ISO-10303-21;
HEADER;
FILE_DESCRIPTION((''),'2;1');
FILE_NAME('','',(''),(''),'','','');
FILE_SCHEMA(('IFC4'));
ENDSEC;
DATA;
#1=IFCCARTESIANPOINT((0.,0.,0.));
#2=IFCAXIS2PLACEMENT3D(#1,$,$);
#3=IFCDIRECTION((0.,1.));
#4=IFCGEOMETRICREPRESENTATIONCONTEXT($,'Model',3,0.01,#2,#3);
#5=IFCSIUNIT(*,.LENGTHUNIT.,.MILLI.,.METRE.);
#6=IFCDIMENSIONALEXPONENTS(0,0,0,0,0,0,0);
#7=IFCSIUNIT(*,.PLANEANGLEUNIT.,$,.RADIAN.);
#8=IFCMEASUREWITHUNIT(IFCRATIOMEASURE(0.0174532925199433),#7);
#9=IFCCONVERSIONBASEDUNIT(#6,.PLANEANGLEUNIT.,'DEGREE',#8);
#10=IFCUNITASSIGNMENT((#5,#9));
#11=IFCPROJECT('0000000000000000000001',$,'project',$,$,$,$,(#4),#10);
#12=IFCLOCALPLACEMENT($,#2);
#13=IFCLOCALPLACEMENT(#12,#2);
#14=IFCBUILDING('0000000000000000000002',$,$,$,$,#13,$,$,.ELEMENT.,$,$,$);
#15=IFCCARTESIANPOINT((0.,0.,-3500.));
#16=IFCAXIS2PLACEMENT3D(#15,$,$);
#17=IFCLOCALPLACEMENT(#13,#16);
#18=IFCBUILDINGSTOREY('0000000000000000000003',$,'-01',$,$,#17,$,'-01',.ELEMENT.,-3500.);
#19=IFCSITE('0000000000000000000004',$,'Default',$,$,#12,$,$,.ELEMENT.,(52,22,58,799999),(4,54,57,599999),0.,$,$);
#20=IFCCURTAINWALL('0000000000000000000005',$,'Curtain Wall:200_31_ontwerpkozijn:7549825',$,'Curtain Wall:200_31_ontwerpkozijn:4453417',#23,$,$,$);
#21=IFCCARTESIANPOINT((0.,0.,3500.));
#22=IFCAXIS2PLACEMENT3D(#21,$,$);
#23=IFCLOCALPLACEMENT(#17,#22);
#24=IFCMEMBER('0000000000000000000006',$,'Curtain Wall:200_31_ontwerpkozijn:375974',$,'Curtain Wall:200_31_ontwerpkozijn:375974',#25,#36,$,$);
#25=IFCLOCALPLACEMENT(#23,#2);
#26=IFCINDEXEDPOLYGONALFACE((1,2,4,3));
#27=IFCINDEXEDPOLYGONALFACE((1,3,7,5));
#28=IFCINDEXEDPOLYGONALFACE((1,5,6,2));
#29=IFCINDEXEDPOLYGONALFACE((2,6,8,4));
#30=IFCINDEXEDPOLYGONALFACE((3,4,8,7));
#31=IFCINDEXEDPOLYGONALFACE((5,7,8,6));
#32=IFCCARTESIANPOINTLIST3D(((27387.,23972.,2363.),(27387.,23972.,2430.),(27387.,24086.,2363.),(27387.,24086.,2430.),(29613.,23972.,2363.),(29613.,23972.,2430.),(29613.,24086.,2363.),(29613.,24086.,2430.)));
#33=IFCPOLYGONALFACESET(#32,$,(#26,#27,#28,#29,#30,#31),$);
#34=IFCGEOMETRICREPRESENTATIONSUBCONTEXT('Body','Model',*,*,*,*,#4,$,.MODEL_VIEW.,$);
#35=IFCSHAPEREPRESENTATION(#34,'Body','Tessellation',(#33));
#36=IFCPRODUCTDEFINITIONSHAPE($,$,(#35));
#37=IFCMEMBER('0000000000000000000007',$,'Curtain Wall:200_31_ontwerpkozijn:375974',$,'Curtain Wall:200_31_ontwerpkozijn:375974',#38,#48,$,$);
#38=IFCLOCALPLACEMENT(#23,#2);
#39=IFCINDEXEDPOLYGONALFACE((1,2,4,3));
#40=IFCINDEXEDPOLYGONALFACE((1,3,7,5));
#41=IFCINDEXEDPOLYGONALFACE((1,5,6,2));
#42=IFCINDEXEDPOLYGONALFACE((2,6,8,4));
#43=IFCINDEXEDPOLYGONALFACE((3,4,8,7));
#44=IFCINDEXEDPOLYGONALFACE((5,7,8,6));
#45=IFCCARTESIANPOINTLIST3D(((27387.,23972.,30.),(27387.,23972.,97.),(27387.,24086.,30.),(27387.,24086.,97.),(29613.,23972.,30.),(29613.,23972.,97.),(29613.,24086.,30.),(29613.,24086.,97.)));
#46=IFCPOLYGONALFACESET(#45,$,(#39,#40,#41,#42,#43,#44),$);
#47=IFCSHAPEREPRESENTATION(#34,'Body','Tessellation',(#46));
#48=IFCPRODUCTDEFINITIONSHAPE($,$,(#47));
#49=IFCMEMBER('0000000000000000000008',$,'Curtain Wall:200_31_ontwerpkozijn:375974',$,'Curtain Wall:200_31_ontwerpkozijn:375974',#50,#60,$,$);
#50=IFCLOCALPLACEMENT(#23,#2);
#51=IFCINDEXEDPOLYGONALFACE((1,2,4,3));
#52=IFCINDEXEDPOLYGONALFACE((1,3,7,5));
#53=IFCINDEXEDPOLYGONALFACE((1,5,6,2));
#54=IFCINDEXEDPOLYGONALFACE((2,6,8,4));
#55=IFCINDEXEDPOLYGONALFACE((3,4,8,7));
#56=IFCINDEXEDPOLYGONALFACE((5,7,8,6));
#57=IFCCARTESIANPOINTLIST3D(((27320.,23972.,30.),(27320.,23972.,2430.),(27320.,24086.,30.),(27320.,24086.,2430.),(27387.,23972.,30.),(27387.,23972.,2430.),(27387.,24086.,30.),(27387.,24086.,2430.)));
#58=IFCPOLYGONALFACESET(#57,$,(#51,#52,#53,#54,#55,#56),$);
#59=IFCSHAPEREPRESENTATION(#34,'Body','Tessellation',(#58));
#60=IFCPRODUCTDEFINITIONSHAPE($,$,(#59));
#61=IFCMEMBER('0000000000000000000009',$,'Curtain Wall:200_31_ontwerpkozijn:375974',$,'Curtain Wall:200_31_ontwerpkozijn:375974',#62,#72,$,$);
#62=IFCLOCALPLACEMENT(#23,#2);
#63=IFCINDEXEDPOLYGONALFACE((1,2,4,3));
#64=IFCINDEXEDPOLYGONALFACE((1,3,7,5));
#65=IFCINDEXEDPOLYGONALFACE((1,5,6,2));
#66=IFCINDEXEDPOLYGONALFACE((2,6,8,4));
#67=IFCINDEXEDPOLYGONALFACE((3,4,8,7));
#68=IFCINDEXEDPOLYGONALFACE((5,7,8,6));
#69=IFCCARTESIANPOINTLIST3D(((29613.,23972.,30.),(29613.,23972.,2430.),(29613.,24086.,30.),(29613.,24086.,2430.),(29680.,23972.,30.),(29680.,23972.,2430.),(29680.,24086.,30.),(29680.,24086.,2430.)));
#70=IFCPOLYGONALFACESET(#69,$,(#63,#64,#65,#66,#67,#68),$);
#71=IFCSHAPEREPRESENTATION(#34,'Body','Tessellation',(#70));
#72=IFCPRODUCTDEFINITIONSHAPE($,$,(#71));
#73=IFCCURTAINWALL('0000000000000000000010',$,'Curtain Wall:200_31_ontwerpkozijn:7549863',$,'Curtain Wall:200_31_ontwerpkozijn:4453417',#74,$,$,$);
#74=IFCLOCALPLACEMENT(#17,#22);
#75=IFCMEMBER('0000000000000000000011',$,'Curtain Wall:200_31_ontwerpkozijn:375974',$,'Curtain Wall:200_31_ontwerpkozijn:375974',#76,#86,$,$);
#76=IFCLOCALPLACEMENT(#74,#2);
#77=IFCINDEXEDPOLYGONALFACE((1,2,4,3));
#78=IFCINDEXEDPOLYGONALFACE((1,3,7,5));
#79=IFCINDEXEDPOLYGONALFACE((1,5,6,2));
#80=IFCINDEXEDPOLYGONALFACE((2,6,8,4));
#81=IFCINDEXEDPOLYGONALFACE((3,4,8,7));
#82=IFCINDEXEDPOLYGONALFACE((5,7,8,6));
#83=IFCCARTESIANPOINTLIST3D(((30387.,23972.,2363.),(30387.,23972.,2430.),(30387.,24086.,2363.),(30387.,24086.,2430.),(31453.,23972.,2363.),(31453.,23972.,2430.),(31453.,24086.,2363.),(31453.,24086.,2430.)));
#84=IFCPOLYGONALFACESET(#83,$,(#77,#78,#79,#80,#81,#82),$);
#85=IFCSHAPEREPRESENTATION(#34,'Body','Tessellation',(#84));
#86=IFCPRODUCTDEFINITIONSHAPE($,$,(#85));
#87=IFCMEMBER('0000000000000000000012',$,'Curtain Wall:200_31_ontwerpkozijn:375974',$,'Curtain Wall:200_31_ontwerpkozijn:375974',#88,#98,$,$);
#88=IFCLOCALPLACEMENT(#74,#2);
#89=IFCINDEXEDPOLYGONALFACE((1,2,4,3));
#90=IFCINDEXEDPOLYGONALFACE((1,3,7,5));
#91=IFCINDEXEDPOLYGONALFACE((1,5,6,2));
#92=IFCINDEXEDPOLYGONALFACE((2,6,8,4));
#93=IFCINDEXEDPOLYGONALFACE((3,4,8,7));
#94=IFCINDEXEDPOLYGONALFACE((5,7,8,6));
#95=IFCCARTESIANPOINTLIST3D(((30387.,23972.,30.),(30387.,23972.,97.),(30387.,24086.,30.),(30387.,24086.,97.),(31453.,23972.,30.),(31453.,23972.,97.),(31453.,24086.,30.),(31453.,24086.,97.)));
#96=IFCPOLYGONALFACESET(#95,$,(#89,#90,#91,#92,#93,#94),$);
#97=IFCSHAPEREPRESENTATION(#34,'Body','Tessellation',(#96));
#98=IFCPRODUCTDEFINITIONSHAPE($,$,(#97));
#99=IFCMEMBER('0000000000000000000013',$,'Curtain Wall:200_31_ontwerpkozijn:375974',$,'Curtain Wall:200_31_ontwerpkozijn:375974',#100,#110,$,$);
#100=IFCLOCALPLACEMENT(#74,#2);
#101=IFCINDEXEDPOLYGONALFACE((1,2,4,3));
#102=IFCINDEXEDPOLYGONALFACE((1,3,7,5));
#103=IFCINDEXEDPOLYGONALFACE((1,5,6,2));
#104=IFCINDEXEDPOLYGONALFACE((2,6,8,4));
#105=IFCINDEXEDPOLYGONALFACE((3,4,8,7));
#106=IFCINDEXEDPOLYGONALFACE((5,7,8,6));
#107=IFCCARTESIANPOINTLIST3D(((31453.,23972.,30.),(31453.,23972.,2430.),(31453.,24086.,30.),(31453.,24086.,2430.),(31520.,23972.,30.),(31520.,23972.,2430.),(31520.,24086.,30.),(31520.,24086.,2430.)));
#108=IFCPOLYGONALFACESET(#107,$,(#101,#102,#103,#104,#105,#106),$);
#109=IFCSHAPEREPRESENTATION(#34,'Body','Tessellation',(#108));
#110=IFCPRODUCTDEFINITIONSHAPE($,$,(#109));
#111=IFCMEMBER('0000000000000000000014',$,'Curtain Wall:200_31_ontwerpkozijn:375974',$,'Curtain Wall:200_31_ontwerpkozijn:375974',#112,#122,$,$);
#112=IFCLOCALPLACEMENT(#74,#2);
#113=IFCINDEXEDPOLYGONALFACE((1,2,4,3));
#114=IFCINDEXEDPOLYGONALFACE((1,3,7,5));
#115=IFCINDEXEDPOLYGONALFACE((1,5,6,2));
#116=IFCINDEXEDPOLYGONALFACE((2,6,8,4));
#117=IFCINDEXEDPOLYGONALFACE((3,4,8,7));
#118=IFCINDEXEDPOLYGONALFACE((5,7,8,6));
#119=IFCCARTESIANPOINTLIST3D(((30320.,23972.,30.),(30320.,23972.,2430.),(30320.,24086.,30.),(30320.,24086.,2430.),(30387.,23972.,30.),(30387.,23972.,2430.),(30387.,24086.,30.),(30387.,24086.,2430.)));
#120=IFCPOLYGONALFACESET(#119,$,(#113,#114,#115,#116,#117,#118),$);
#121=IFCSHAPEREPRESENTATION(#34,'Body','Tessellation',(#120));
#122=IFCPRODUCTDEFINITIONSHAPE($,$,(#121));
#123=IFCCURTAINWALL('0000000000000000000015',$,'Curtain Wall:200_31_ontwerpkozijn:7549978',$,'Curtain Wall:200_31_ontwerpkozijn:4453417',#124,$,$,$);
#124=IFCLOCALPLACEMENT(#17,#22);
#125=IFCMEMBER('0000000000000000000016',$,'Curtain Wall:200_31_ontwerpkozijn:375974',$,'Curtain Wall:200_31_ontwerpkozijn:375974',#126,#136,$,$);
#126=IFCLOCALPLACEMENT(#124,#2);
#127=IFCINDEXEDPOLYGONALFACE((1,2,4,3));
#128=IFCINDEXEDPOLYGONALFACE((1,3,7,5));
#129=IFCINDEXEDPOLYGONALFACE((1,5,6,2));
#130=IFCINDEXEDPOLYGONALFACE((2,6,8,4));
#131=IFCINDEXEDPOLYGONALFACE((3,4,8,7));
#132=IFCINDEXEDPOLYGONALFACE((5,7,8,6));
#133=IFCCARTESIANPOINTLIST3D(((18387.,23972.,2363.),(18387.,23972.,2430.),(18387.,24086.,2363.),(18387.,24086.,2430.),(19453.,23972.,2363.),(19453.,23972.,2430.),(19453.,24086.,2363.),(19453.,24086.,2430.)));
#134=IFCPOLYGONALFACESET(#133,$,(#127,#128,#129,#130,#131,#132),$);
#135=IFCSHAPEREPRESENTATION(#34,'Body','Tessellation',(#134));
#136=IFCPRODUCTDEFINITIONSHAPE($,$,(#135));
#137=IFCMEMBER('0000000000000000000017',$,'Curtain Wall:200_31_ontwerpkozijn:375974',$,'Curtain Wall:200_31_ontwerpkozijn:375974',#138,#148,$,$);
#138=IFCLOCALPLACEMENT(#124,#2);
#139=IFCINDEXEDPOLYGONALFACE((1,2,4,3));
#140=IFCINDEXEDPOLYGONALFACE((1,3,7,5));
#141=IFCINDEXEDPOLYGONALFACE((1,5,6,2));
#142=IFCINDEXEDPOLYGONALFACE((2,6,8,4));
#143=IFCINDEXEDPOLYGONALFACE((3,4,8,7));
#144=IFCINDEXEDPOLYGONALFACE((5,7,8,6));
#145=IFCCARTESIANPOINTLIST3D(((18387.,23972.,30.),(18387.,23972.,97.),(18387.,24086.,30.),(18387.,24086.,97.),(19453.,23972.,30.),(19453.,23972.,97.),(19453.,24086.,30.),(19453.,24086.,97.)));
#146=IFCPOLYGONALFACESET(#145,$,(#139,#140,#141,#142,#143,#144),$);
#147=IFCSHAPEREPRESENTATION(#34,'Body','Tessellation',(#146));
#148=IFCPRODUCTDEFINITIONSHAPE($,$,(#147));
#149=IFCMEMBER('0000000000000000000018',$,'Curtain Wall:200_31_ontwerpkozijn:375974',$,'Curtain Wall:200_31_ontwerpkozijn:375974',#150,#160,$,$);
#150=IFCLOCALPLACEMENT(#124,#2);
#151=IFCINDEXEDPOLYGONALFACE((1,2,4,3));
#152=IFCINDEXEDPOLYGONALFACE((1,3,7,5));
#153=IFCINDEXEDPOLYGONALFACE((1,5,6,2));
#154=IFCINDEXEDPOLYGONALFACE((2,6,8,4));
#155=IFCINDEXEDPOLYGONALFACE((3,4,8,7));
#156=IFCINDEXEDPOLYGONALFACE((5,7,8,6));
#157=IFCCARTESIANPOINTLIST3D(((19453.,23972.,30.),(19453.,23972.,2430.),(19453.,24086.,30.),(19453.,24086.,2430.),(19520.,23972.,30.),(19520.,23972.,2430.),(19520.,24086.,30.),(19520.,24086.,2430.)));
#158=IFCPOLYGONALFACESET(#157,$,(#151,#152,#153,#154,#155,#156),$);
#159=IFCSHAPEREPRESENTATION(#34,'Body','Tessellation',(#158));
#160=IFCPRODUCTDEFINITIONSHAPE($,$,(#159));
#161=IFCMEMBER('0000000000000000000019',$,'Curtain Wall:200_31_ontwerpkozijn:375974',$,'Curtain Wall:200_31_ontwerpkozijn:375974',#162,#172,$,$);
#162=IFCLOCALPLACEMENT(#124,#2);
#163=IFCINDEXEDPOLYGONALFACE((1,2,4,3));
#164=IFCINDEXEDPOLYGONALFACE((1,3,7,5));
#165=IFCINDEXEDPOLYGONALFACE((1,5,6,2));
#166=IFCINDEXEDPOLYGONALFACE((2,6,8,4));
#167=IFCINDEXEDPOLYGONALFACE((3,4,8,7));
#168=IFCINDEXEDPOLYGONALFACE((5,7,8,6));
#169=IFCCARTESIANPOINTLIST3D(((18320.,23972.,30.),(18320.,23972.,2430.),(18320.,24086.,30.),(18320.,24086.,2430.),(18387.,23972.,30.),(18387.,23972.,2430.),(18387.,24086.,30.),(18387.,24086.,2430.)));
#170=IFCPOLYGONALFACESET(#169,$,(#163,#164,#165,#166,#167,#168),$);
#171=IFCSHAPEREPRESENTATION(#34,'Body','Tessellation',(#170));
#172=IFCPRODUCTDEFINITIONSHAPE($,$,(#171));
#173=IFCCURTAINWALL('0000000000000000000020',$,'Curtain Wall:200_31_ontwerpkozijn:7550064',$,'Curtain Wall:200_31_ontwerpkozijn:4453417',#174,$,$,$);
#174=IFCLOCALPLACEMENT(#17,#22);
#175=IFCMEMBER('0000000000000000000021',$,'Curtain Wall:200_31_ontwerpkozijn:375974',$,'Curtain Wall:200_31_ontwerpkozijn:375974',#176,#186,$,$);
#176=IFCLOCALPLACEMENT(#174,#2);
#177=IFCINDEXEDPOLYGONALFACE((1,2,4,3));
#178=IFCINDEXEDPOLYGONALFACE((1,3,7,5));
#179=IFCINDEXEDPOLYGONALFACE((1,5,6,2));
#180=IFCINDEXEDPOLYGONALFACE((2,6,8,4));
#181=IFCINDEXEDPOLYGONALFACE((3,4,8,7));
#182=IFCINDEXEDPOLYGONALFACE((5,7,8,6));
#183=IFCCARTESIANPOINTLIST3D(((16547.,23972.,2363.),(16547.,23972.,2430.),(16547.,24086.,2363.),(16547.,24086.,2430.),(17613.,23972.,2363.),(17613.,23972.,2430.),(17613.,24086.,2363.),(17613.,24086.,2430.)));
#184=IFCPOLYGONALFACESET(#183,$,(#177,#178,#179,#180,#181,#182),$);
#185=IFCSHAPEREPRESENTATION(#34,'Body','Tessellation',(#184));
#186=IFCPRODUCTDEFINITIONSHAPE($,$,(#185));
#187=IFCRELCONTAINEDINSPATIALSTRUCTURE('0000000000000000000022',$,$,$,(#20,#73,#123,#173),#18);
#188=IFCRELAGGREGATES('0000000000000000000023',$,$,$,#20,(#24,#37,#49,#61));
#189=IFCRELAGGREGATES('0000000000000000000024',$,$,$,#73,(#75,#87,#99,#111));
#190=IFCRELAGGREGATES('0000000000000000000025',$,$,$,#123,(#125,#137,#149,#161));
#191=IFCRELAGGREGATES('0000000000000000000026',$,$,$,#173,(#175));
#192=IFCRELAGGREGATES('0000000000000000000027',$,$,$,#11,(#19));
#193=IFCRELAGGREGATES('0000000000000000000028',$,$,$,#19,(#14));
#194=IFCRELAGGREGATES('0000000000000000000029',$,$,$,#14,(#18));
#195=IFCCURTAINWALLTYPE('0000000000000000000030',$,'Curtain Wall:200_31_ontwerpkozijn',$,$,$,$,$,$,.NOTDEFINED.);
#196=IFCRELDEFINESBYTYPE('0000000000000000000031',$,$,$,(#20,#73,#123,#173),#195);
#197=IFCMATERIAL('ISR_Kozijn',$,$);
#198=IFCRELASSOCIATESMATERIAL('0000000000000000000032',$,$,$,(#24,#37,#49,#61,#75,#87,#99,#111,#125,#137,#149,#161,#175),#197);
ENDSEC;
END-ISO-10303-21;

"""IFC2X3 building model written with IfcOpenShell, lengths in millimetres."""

from ifc_helpers import new_model, entity, si_unit, converted_unit, direction, frame, frame_2d, origin, origin_2d_with_axis, place, context, subcontext, project, spatial, rectangle, extrude, material, type_object, element, aggregate, save


model = new_model("IFC2X3")

# Units and contexts
model_context = context("Model", 3, precision=0.01, world=origin(), true_north=direction((0.0, 1.0)))
body_context = subcontext(model_context, "Body", "Model", "MODEL_VIEW")
ifc_project = project(units=[si_unit("LENGTHUNIT", "METRE", prefix="MILLI"), converted_unit("PLANEANGLEUNIT", "DEGREE", entity("IfcRatioMeasure", 0.0174532925199433), si_unit("PLANEANGLEUNIT", "RADIAN"), dimensions=[0, 0, 0, 0, 0, 0, 0])], contexts=[model_context])

# Site, building, storey
site_placement = place(None, origin())
site = spatial("IfcSite", under=ifc_project, at=site_placement, Name="Default", CompositionType="ELEMENT", RefLatitude=(52, 22, 58, 799999), RefLongitude=(4, 54, 57, 599999), RefElevation=0.0)
building_placement = place(site_placement, origin())
building = spatial("IfcBuilding", under=site, at=building_placement, CompositionType="ELEMENT")
storey_placement = place(building_placement, frame((0.0, 0.0, -3500.0)))
storey = spatial("IfcBuildingStorey", under=building, at=storey_placement, Name="-01", LongName="-01", CompositionType="ELEMENT", Elevation=-3500.0)

# Shared definitions
curtain_wall_type = type_object("IfcCurtainWallType", Name="Curtain Wall:200_31_ontwerpkozijn", PredefinedType="NOTDEFINED")
ifc_material = material(Name="ISR_Kozijn")

# Curtain walls, members
curtain_wall_1_placement = place(storey_placement, frame((0.0, 0.0, 3500.0)))
curtain_wall_1 = element("IfcCurtainWall", 1, at=curtain_wall_1_placement, inside=storey, type_object=curtain_wall_type, Name="Curtain Wall:200_31_ontwerpkozijn:7549825", ObjectType="Curtain Wall:200_31_ontwerpkozijn:4453417")
member_1_placement = place(curtain_wall_1_placement, origin())
member_1 = element("IfcMember", 2, at=member_1_placement, material=ifc_material, Name="Curtain Wall:200_31_ontwerpkozijn:375974", ObjectType="Curtain Wall:200_31_ontwerpkozijn:375974", context=body_context, shape_type="SweptSolid", body=[
    extrude(rectangle(XDim=67.0, YDim=114.0, at=origin_2d_with_axis()), frame((27387.0, 24029.0, 2396.5), z_axis=(1.0, 0.0, 0.0), x_axis=(0.0, 0.0, -1.0)), (0.0, 0.0, 1.0), 2226.0),
])
member_2_placement = place(curtain_wall_1_placement, origin())
member_2 = element("IfcMember", 3, at=member_2_placement, material=ifc_material, Name="Curtain Wall:200_31_ontwerpkozijn:375974", ObjectType="Curtain Wall:200_31_ontwerpkozijn:375974", context=body_context, shape_type="SweptSolid", body=[
    extrude(rectangle(XDim=67.0, YDim=114.0, at=origin_2d_with_axis()), frame((29613.0, 24029.0, 63.5), z_axis=(-1.0, 0.0, 0.0), x_axis=(0.0, 0.0, -1.0)), (0.0, 0.0, 1.0), 2226.0),
])
member_3_placement = place(curtain_wall_1_placement, origin())
member_3 = element("IfcMember", 4, at=member_3_placement, material=ifc_material, Name="Curtain Wall:200_31_ontwerpkozijn:375974", ObjectType="Curtain Wall:200_31_ontwerpkozijn:375974", context=body_context, shape_type="SweptSolid", body=[
    extrude(rectangle(XDim=67.0, YDim=114.0, at=origin_2d_with_axis()), frame((27353.5, 24029.0, 30.0), z_axis=(0.0, 0.0, 1.0), x_axis=(-1.0, 0.0, 0.0)), (0.0, 0.0, 1.0), 2400.0),
])
member_4_placement = place(curtain_wall_1_placement, origin())
member_4 = element("IfcMember", 5, at=member_4_placement, material=ifc_material, Name="Curtain Wall:200_31_ontwerpkozijn:375974", ObjectType="Curtain Wall:200_31_ontwerpkozijn:375974", context=body_context, shape_type="SweptSolid", body=[
    extrude(rectangle(XDim=67.0, YDim=114.0, at=origin_2d_with_axis()), frame((29646.5, 24029.0, 2430.0), z_axis=(0.0, 0.0, -1.0), x_axis=(-1.0, 0.0, 0.0)), (0.0, 0.0, 1.0), 2400.0),
])
aggregate(curtain_wall_1, [member_1, member_2, member_3, member_4])
curtain_wall_2_placement = place(storey_placement, frame((0.0, 0.0, 3500.0)))
curtain_wall_2 = element("IfcCurtainWall", 6, at=curtain_wall_2_placement, inside=storey, type_object=curtain_wall_type, Name="Curtain Wall:200_31_ontwerpkozijn:7549863", ObjectType="Curtain Wall:200_31_ontwerpkozijn:4453417")
member_5_placement = place(curtain_wall_2_placement, origin())
member_5 = element("IfcMember", 7, at=member_5_placement, material=ifc_material, Name="Curtain Wall:200_31_ontwerpkozijn:375974", ObjectType="Curtain Wall:200_31_ontwerpkozijn:375974", context=body_context, shape_type="SweptSolid", body=[
    extrude(rectangle(XDim=67.0, YDim=114.0, at=origin_2d_with_axis()), frame((31453.0, 24029.0, 2396.5), z_axis=(-1.0, 0.0, 0.0), x_axis=(0.0, 0.0, -1.0)), (0.0, 0.0, 1.0), 1066.0),
])
member_6_placement = place(curtain_wall_2_placement, origin())
member_6 = element("IfcMember", 8, at=member_6_placement, material=ifc_material, Name="Curtain Wall:200_31_ontwerpkozijn:375974", ObjectType="Curtain Wall:200_31_ontwerpkozijn:375974", context=body_context, shape_type="SweptSolid", body=[
    extrude(rectangle(XDim=67.0, YDim=114.0, at=origin_2d_with_axis()), frame((30387.0, 24029.0, 63.5), z_axis=(1.0, 0.0, 0.0), x_axis=(0.0, 0.0, -1.0)), (0.0, 0.0, 1.0), 1066.0),
])
member_7_placement = place(curtain_wall_2_placement, origin())
member_7 = element("IfcMember", 9, at=member_7_placement, material=ifc_material, Name="Curtain Wall:200_31_ontwerpkozijn:375974", ObjectType="Curtain Wall:200_31_ontwerpkozijn:375974", context=body_context, shape_type="SweptSolid", body=[
    extrude(rectangle(XDim=67.0, YDim=114.0, at=origin_2d_with_axis()), frame((31486.5, 24029.0, 30.0), z_axis=(0.0, 0.0, 1.0), x_axis=(-1.0, 0.0, 0.0)), (0.0, 0.0, 1.0), 2400.0),
])
member_8_placement = place(curtain_wall_2_placement, origin())
member_8 = element("IfcMember", 10, at=member_8_placement, material=ifc_material, Name="Curtain Wall:200_31_ontwerpkozijn:375974", ObjectType="Curtain Wall:200_31_ontwerpkozijn:375974", context=body_context, shape_type="SweptSolid", body=[
    extrude(rectangle(XDim=67.0, YDim=114.0, at=origin_2d_with_axis()), frame((30353.5, 24029.0, 2430.0), z_axis=(0.0, 0.0, -1.0), x_axis=(-1.0, 0.0, 0.0)), (0.0, 0.0, 1.0), 2400.0),
])
aggregate(curtain_wall_2, [member_5, member_6, member_7, member_8])
curtain_wall_3_placement = place(storey_placement, frame((0.0, 0.0, 3500.0)))
curtain_wall_3 = element("IfcCurtainWall", 11, at=curtain_wall_3_placement, inside=storey, type_object=curtain_wall_type, Name="Curtain Wall:200_31_ontwerpkozijn:7549978", ObjectType="Curtain Wall:200_31_ontwerpkozijn:4453417")
member_9_placement = place(curtain_wall_3_placement, origin())
member_9 = element("IfcMember", 12, at=member_9_placement, material=ifc_material, Name="Curtain Wall:200_31_ontwerpkozijn:375974", ObjectType="Curtain Wall:200_31_ontwerpkozijn:375974", context=body_context, shape_type="SweptSolid", body=[
    extrude(rectangle(XDim=67.0, YDim=114.0, at=origin_2d_with_axis()), frame((19453.0, 24029.0, 2396.5), z_axis=(-1.0, 0.0, 0.0), x_axis=(0.0, 0.0, -1.0)), (0.0, 0.0, 1.0), 1066.0),
])
member_10_placement = place(curtain_wall_3_placement, origin())
member_10 = element("IfcMember", 13, at=member_10_placement, material=ifc_material, Name="Curtain Wall:200_31_ontwerpkozijn:375974", ObjectType="Curtain Wall:200_31_ontwerpkozijn:375974", context=body_context, shape_type="SweptSolid", body=[
    extrude(rectangle(XDim=67.0, YDim=114.0, at=origin_2d_with_axis()), frame((18387.0, 24029.0, 63.5), z_axis=(1.0, 0.0, 0.0), x_axis=(0.0, 0.0, -1.0)), (0.0, 0.0, 1.0), 1066.0),
])
member_11_placement = place(curtain_wall_3_placement, origin())
member_11 = element("IfcMember", 14, at=member_11_placement, material=ifc_material, Name="Curtain Wall:200_31_ontwerpkozijn:375974", ObjectType="Curtain Wall:200_31_ontwerpkozijn:375974", context=body_context, shape_type="SweptSolid", body=[
    extrude(rectangle(XDim=67.0, YDim=114.0, at=frame_2d((0.0, 0.0), x_axis=(1.0, 0.0))), frame((19486.5, 24029.0, 30.0), z_axis=(0.0, 0.0, 1.0), x_axis=(-1.0, 0.0, 0.0)), (0.0, 0.0, 1.0), 2400.0),
])
member_12_placement = place(curtain_wall_3_placement, origin())
member_12 = element("IfcMember", 15, at=member_12_placement, material=ifc_material, Name="Curtain Wall:200_31_ontwerpkozijn:375974", ObjectType="Curtain Wall:200_31_ontwerpkozijn:375974", context=body_context, shape_type="SweptSolid", body=[
    extrude(rectangle(XDim=67.0, YDim=114.0, at=frame_2d((0.0, 0.0), x_axis=(1.0, 0.0))), frame((18353.5, 24029.0, 2430.0), z_axis=(0.0, 0.0, -1.0), x_axis=(-1.0, 0.0, 0.0)), (0.0, 0.0, 1.0), 2400.0),
])
aggregate(curtain_wall_3, [member_9, member_10, member_11, member_12])
curtain_wall_4_placement = place(storey_placement, frame((0.0, 0.0, 3500.0)))
curtain_wall_4 = element("IfcCurtainWall", 16, at=curtain_wall_4_placement, inside=storey, type_object=curtain_wall_type, Name="Curtain Wall:200_31_ontwerpkozijn:7550064", ObjectType="Curtain Wall:200_31_ontwerpkozijn:4453417")
member_13_placement = place(curtain_wall_4_placement, origin())
member_13 = element("IfcMember", 17, at=member_13_placement, material=ifc_material, Name="Curtain Wall:200_31_ontwerpkozijn:375974", ObjectType="Curtain Wall:200_31_ontwerpkozijn:375974", context=body_context, shape_type="SweptSolid", body=[
    extrude(rectangle(XDim=67.0, YDim=114.0, at=origin_2d_with_axis()), frame((16547.0, 24029.0, 2396.5), z_axis=(1.0, 0.0, 0.0), x_axis=(0.0, 0.0, -1.0)), (0.0, 0.0, 1.0), 1066.0),
])
aggregate(curtain_wall_4, [member_13])

save(model, "model.ifc")
